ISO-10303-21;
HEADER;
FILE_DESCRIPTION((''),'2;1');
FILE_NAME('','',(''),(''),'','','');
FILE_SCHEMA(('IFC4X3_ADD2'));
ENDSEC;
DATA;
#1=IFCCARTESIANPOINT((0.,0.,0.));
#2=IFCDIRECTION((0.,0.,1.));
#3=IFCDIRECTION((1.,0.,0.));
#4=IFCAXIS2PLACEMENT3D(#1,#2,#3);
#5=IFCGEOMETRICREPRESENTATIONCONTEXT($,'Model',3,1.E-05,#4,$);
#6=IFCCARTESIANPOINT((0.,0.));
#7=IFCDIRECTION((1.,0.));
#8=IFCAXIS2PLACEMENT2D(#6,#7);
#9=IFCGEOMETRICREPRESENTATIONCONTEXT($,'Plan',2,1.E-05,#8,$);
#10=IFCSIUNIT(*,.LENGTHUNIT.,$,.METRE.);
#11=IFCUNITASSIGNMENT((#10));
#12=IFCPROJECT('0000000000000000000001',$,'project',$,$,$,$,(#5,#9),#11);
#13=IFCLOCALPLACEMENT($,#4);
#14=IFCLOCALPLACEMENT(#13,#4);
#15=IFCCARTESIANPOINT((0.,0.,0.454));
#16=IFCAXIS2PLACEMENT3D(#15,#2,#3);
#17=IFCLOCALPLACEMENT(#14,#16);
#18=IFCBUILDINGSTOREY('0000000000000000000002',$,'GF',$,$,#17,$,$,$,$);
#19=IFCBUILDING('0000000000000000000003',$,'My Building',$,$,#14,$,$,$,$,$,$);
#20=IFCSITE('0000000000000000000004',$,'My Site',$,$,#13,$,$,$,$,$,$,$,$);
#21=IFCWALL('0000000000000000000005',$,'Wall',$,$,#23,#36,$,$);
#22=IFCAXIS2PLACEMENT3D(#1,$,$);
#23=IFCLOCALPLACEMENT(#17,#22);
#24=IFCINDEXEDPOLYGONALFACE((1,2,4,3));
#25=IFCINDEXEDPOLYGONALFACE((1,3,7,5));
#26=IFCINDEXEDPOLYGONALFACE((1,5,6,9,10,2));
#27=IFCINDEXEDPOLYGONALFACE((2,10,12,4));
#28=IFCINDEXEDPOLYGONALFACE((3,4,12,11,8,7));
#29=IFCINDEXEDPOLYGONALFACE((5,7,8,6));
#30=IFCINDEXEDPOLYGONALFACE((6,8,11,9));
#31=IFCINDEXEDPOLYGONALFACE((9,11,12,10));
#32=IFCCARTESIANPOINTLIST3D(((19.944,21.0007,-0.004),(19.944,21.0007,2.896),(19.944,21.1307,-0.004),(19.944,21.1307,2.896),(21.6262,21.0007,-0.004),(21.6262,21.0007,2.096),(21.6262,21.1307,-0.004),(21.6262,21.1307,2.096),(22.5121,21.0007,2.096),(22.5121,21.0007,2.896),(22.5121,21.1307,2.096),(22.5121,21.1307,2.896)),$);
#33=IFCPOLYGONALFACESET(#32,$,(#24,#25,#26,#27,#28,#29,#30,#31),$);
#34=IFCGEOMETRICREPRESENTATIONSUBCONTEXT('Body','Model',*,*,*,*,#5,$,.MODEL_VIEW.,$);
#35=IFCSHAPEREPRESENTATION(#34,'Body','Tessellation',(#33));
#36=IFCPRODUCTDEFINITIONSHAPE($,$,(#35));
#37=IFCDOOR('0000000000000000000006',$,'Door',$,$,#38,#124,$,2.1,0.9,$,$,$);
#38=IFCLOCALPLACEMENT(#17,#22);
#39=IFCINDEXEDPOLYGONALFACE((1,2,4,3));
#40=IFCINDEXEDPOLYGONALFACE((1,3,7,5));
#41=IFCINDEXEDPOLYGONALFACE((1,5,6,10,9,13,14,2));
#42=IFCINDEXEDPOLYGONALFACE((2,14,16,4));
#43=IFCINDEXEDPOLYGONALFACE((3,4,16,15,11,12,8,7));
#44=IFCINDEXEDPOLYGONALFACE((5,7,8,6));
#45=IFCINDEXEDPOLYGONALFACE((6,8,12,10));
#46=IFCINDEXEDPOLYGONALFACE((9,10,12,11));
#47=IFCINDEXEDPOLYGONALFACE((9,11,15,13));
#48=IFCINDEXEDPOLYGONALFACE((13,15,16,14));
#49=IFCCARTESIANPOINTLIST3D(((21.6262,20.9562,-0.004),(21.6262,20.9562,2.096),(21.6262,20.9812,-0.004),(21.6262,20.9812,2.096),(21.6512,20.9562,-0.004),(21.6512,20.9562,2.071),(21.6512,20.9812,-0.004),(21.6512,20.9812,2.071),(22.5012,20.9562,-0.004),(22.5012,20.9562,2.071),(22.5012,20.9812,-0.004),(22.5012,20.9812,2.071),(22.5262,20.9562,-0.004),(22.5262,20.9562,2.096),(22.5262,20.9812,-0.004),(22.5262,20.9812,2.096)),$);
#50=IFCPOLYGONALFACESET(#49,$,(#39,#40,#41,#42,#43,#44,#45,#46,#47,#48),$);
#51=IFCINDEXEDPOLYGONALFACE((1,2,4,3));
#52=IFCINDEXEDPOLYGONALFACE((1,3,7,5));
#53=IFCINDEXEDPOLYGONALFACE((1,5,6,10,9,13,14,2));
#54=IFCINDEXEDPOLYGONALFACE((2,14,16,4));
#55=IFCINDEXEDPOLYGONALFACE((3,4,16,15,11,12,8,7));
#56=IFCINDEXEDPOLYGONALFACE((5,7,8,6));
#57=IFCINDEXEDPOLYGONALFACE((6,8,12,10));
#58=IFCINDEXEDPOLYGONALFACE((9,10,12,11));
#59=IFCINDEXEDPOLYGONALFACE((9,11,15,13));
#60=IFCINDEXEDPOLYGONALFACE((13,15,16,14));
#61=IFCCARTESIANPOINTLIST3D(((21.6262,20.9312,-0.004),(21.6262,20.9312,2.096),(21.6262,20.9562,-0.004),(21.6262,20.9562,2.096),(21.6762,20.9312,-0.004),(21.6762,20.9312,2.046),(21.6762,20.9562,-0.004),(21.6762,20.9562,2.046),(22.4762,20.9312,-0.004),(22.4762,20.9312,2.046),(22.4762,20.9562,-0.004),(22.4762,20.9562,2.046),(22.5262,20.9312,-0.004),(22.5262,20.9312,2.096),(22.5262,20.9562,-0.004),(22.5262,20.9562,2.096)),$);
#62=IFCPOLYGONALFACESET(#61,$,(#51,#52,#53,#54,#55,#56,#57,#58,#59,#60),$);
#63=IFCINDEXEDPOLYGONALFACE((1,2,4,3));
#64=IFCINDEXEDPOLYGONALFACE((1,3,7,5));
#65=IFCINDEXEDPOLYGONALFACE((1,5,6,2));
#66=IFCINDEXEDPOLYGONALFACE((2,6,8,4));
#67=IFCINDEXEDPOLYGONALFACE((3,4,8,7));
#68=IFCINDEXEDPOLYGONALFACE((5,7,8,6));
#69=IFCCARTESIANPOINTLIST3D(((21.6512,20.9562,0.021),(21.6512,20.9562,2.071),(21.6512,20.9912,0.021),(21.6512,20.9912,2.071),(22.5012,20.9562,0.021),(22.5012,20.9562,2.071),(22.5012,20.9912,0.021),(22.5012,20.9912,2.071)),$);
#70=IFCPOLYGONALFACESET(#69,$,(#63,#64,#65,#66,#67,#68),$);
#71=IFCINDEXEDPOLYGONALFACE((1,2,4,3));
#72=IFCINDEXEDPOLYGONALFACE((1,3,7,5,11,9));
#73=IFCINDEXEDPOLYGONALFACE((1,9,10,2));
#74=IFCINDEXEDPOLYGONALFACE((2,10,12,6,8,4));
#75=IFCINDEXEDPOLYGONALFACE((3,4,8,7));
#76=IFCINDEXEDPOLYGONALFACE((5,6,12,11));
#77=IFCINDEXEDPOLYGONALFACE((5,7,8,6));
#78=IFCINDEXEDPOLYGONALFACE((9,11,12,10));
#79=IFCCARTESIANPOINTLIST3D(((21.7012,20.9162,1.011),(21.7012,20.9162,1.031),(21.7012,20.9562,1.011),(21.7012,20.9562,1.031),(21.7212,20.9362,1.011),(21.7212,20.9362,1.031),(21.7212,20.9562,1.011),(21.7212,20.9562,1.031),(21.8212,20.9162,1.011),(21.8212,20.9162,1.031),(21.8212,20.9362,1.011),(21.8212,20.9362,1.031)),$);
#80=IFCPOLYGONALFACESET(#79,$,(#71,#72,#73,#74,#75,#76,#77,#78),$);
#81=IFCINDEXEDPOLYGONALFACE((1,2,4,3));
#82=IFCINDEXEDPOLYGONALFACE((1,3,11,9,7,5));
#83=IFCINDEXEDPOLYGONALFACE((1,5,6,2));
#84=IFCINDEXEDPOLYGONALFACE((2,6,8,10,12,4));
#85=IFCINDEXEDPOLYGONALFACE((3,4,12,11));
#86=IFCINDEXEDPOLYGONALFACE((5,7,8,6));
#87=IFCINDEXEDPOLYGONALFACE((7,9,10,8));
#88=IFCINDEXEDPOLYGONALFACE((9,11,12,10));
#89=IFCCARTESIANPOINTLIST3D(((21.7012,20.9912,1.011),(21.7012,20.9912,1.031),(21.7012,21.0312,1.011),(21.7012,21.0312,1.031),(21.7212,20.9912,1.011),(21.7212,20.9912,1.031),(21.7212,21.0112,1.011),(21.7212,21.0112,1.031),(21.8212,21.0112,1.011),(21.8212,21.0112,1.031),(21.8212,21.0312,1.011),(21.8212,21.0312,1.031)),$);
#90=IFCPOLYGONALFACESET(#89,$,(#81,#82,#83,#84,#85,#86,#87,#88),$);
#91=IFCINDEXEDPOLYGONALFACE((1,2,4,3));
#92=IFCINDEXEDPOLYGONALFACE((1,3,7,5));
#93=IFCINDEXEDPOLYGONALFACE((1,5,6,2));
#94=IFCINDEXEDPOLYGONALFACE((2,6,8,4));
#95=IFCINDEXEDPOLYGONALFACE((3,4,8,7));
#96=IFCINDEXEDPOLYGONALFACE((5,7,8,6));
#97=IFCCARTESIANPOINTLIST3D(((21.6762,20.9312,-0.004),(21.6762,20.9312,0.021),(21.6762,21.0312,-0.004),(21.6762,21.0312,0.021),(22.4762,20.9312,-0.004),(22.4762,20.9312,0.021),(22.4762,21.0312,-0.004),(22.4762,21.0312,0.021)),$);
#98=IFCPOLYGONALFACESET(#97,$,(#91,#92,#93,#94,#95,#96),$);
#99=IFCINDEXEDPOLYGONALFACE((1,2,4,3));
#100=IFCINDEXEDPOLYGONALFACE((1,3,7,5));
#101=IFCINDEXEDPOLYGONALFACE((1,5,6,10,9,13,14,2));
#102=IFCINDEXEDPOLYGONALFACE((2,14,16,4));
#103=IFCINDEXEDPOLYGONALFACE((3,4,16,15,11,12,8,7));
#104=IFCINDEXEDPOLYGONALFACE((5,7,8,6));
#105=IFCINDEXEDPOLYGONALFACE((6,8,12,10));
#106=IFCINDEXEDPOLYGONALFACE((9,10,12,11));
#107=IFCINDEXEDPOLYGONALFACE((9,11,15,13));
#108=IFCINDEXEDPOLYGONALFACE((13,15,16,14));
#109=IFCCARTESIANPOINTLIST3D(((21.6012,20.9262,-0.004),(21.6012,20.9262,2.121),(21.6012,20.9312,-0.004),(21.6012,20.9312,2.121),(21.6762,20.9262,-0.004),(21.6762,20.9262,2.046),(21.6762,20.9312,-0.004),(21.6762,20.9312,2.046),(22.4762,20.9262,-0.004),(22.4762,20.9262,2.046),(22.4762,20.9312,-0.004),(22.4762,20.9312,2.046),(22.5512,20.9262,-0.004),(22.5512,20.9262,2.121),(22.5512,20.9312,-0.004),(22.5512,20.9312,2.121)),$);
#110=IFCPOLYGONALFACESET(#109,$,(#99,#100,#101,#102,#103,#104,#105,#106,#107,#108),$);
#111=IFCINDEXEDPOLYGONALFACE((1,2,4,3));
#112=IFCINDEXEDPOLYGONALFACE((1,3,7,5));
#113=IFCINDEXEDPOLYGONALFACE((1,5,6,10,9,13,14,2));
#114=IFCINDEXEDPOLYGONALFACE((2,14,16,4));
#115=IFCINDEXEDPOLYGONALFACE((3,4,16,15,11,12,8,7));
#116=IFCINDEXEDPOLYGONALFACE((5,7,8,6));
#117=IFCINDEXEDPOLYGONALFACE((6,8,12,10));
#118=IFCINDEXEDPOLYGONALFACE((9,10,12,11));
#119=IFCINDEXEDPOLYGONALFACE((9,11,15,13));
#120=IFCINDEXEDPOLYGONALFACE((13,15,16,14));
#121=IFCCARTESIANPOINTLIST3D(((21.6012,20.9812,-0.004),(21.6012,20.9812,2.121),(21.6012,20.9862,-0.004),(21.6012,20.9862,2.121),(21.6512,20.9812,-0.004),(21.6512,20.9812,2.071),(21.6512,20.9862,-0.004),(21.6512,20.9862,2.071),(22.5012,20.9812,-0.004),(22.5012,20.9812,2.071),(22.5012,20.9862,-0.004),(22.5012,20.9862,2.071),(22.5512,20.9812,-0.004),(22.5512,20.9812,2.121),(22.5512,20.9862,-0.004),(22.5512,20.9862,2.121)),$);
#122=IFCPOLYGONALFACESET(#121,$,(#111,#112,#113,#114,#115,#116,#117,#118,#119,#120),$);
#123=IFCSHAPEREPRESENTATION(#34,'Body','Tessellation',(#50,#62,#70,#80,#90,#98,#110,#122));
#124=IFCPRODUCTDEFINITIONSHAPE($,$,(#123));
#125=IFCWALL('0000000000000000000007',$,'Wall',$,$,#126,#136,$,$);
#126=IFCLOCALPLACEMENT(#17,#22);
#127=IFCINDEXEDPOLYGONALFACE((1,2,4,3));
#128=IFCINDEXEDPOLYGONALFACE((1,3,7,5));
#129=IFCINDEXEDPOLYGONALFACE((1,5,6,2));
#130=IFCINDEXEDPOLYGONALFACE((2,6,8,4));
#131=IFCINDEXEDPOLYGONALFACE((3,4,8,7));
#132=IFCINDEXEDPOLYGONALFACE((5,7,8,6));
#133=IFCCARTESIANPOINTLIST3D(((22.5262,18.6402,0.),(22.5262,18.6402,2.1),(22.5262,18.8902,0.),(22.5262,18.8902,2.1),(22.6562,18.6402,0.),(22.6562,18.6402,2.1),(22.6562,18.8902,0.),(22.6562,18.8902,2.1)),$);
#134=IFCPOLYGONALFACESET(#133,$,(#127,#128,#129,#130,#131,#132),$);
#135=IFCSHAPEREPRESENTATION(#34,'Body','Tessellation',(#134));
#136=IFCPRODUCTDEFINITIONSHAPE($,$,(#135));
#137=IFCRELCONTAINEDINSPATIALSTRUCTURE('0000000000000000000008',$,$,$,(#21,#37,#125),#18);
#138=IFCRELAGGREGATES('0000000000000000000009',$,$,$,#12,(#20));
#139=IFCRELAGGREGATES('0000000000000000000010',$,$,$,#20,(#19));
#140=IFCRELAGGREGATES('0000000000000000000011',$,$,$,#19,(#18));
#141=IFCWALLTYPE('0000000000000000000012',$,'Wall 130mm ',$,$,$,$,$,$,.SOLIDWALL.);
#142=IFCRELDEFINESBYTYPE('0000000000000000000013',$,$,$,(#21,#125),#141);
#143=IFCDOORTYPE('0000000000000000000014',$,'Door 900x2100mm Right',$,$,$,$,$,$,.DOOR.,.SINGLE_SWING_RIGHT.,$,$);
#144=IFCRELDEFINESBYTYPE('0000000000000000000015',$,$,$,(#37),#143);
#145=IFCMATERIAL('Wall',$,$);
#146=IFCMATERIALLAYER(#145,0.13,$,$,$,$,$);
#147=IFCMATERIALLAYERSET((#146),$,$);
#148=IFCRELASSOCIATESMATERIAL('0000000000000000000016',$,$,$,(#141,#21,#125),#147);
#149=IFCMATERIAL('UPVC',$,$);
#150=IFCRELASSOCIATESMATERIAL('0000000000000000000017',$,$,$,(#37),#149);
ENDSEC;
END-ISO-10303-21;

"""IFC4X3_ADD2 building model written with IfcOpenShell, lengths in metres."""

from ifc_helpers import new_model, entity, si_unit, frame, origin_with_axes, origin_2d_with_axis, place, context, subcontext, project, spatial, line, indexed_curve, outline, extrude, clip, halfspace, shape, source, transform, mapped, material, layer, layer_set, layer_usage, type_object, type_shapes, element, fill, save


model = new_model("IFC4X3_ADD2")

# Units and contexts
model_context = context("Model", 3, precision=1e-05, world=origin_with_axes())
plan_context = context("Plan", 2, precision=1e-05, world=origin_2d_with_axis())
body_context_1 = subcontext(model_context, "Body", "Model", "MODEL_VIEW")
body_context_2 = subcontext(plan_context, "Body", "Plan", "PLAN_VIEW")
ifc_project = project(units=[si_unit("LENGTHUNIT", "METRE")], contexts=[model_context, plan_context])

# Site, building, storey
site_placement = place(None, origin_with_axes())
site = spatial("IfcSite", under=ifc_project, at=site_placement, Name="My Site")
building_placement = place(site_placement, origin_with_axes())
building = spatial("IfcBuilding", under=site, at=building_placement, Name="My Building")
storey_placement = place(building_placement, frame((0.0, 0.0, 0.454), z_axis=(0.0, 0.0, 1.0), x_axis=(1.0, 0.0, 0.0)))
storey = spatial("IfcBuildingStorey", under=building, at=storey_placement, Name="GF")

# Wall, opening, door
ifc_material_1 = material(Name="Wall")
ifc_layer_1 = layer(ifc_material_1, 0.13)
ifc_layer_set_1 = layer_set([ifc_layer_1])
ifc_layer_usage_1 = layer_usage(ifc_layer_set_1, "AXIS2", "POSITIVE", 0.0)
wall_type_1 = type_object("IfcWallType", Name="Wall 130mm ", PredefinedType="SOLIDWALL", material=ifc_layer_set_1)
wall_1_placement = place(storey_placement, frame((22.5121, 21.1307, -0.004), z_axis=(0.0, 0.0, 1.0), x_axis=(-1.0, 0.0, 0.0)))
wall_1 = element("IfcWall", 1, at=wall_1_placement, inside=storey, type_object=wall_type_1, material=ifc_layer_usage_1, Name="Wall", context=body_context_1, shape_type="SweptSolid", body=[
    extrude(outline(indexed_curve([(0.0, 0.0), (0.0, 0.13), (2.5681, 0.13), (2.5681, 0.0), (0.0, 0.0)], self_intersect=False)), origin_with_axes(), (0.0, 0.0, 1.0), 2.9),
])
shared_shape_1 = source(origin_with_axes(), body_context_1, "Body", "SweptSolid", [
    extrude(outline(indexed_curve([(0.0, 0.0), (0.9, 0.0), (0.9, 2.1), (0.0, 2.1)], segments=[line(1, 2, 3, 4, 1)])), frame((0.0, -0.6, 0.0), z_axis=(0.0, -1.0, 0.0), x_axis=(1.0, 0.0, 0.0)), (0.0, 0.0, -1.0), 1.2),
])
opening_1_placement = place(wall_1_placement, frame((0.8859, 0.1995, 0.0), z_axis=(0.0, 0.0, 1.0), x_axis=(-1.0, 0.0, 0.0)))
opening_1 = element("IfcOpeningElement", 2, at=opening_1_placement, cuts=wall_1, PredefinedType="OPENING", context=body_context_1, shape_type="MappedRepresentation", body=[
    mapped(shared_shape_1, transform((0.0, 0.0, 0.0), x_axis=(1.0, 0.0, 0.0), y_axis=(0.0, 1.0, 0.0), z_axis=(0.0, 0.0, 1.0), scale=1.0)),
])
ifc_material_2 = material(Name="UPVC")
door_type_1 = type_object("IfcDoorType", Name="Door 900x2100mm Right", OperationType="SINGLE_SWING_RIGHT", PredefinedType="DOOR")
shared_shape_2 = source(origin_with_axes(), body_context_1, "Body", "SweptSolid", [
    extrude(outline(indexed_curve([(0.0, 0.0), (0.0, 2.1), (0.9, 2.1), (0.9, 0.0), (0.875, 0.0), (0.875, 2.075), (0.025, 2.075), (0.025, 0.0)], segments=[line(1, 2, 3, 4, 5, 6, 7, 8, 1)])), frame((0.0, 0.025, 0.0), z_axis=(0.0, -1.0, 0.0), x_axis=(1.0, 0.0, 0.0)), (0.0, 0.0, -1.0), 0.025),
    extrude(outline(indexed_curve([(0.0, 0.0), (0.0, 2.1), (0.9, 2.1), (0.9, 0.0), (0.85, 0.0), (0.85, 2.05), (0.05, 2.05), (0.05, 0.0)], segments=[line(1, 2, 3, 4, 5, 6, 7, 8, 1)])), frame((0.0, 0.0, 0.0), z_axis=(0.0, -1.0, 0.0), x_axis=(1.0, 0.0, 0.0)), (0.0, 0.0, -1.0), 0.025),
    extrude(outline(indexed_curve([(0.0, 0.0), (0.85, 0.0), (0.85, 0.035), (0.0, 0.035)], segments=[line(1, 2, 3, 4, 1)])), frame((0.025, 0.025, 0.025), z_axis=(0.0, 0.0, 1.0), x_axis=(1.0, 0.0, 0.0)), (0.0, 0.0, 1.0), 2.05),
    extrude(outline(indexed_curve([(0.0, 0.0), (0.0, -0.04), (0.12, -0.04), (0.12, -0.02), (0.02, -0.02), (0.02, 0.0)], segments=[line(1, 2, 3, 4, 5, 6, 1)])), frame((0.075, 0.025, 1.015), z_axis=(0.0, 0.0, 1.0), x_axis=(1.0, 0.0, 0.0)), (0.0, 0.0, 1.0), 0.02),
    extrude(outline(indexed_curve([(0.0, 0.0), (0.0, 0.04), (0.12, 0.04), (0.12, 0.02), (0.02, 0.02), (0.02, 0.0)], segments=[line(1, 2, 3, 4, 5, 6, 1)])), frame((0.075, 0.06, 1.015), z_axis=(0.0, 0.0, 1.0), x_axis=(1.0, 0.0, 0.0)), (0.0, 0.0, 1.0), 0.02),
    extrude(outline(indexed_curve([(0.0, 0.0), (0.8, 0.0), (0.8, 0.1), (0.0, 0.1)], segments=[line(1, 2, 3, 4, 1)])), frame((0.05, 0.0, 0.0), z_axis=(0.0, 0.0, 1.0), x_axis=(1.0, 0.0, 0.0)), (0.0, 0.0, 1.0), 0.025),
    extrude(outline(indexed_curve([(0.0, 0.0), (0.0, 2.125), (0.95, 2.125), (0.95, 0.0), (0.875, 0.0), (0.875, 2.05), (0.075, 2.05), (0.075, 0.0)], segments=[line(1, 2, 3, 4, 5, 6, 7, 8, 1)])), frame((-0.025, -0.005, 0.0), z_axis=(0.0, -1.0, 0.0), x_axis=(1.0, 0.0, 0.0)), (0.0, 0.0, -1.0), 0.005),
    extrude(outline(indexed_curve([(0.0, 0.0), (0.0, 2.125), (0.95, 2.125), (0.95, 0.0), (0.9, 0.0), (0.9, 2.075), (0.05, 2.075), (0.05, 0.0)], segments=[line(1, 2, 3, 4, 5, 6, 7, 8, 1)])), frame((-0.025, 0.05, 0.0), z_axis=(0.0, -1.0, 0.0), x_axis=(1.0, 0.0, 0.0)), (0.0, 0.0, -1.0), 0.005),
])
shared_shape_3 = source(origin_with_axes(), body_context_2, "Body", "Curve2D", [
    entity("IfcIndexedPolyCurve", entity("IfcCartesianPointList2D", [[0.0, 0.0], [0.0, 0.05], [0.025, 0.05], [0.025, 0.025], [0.05, 0.025], [0.05, 0.0]]), [entity("IfcLineIndex", [1, 2, 3, 4, 5, 6, 1])]),
    entity("IfcIndexedPolyCurve", entity("IfcCartesianPointList2D", [[0.9, 0.0], [0.9, 0.05], [0.875, 0.05], [0.875, 0.025], [0.85, 0.025], [0.85, 0.0]]), [entity("IfcLineIndex", [1, 2, 3, 4, 5, 6, 1])]),
    entity("IfcTrimmedCurve", entity("IfcEllipse", entity("IfcAxis2Placement2D", entity("IfcCartesianPoint", [0.84, 0.05]), entity("IfcDirection", [1.0, 0.0])), 0.815, 0.85), [entity("IfcCartesianPoint", [0.84, 0.9])], [entity("IfcCartesianPoint", [0.025, 0.05])], True, "CARTESIAN"),
    entity("IfcIndexedPolyCurve", entity("IfcCartesianPointList2D", [[0.875, 0.05], [0.84, 0.05], [0.84, 0.9], [0.875, 0.9]]), [entity("IfcLineIndex", [1, 2, 3, 4, 1])]),
])
type_shapes(door_type_1, [shared_shape_2, shared_shape_3])
door_1_placement = place(opening_1_placement, frame((0.0, 0.0, 0.0), z_axis=(0.0, 0.0, 1.0), x_axis=(1.0, 0.0, 0.0)))
door_1 = element("IfcDoor", 3, at=door_1_placement, inside=storey, type_object=door_type_1, material=ifc_material_2, Name="Door", OverallHeight=2.1, OverallWidth=0.9, shapes=[
    shape(body_context_1, "Body", "MappedRepresentation", [mapped(shared_shape_2, transform((0.0, 0.0, 0.0), x_axis=(1.0, 0.0, 0.0), y_axis=(0.0, 1.0, 0.0), z_axis=(0.0, 0.0, 1.0), scale=1.0))]),
    shape(body_context_2, "Body", "MappedRepresentation", [mapped(shared_shape_3, transform((0.0, 0.0, 0.0), x_axis=(1.0, 0.0, 0.0), y_axis=(0.0, 1.0, 0.0), z_axis=(0.0, 0.0, 1.0), scale=1.0))]),
])
fill(opening_1, door_1)

# Wall
ifc_layer_usage_2 = layer_usage(ifc_layer_set_1, "AXIS2", "POSITIVE", 0.0)
wall_2_placement = place(storey_placement, frame((22.6562, 18.6402, 0.0), z_axis=(0.0, 0.0, 1.0), x_axis=(0.000002, 1.0, 0.0)))
element("IfcWall", 4, at=wall_2_placement, inside=storey, type_object=wall_type_1, material=ifc_layer_usage_2, Name="Wall", context=body_context_1, shape_type="Clipping", body=[
    clip(extrude(outline(indexed_curve([(0.0, 0.0), (0.0, 0.13), (0.25, 0.13), (0.25, 0.0), (0.0, 0.0)], self_intersect=False)), origin_with_axes(), (0.0, 0.0, 1.0), 2.554), halfspace(frame((0.0, 0.0, 2.1), z_axis=(0.0, 0.0, 1.0), x_axis=(-1.0, 0.0, 0.0)), False)),
])

save(model, "model.ifc")
